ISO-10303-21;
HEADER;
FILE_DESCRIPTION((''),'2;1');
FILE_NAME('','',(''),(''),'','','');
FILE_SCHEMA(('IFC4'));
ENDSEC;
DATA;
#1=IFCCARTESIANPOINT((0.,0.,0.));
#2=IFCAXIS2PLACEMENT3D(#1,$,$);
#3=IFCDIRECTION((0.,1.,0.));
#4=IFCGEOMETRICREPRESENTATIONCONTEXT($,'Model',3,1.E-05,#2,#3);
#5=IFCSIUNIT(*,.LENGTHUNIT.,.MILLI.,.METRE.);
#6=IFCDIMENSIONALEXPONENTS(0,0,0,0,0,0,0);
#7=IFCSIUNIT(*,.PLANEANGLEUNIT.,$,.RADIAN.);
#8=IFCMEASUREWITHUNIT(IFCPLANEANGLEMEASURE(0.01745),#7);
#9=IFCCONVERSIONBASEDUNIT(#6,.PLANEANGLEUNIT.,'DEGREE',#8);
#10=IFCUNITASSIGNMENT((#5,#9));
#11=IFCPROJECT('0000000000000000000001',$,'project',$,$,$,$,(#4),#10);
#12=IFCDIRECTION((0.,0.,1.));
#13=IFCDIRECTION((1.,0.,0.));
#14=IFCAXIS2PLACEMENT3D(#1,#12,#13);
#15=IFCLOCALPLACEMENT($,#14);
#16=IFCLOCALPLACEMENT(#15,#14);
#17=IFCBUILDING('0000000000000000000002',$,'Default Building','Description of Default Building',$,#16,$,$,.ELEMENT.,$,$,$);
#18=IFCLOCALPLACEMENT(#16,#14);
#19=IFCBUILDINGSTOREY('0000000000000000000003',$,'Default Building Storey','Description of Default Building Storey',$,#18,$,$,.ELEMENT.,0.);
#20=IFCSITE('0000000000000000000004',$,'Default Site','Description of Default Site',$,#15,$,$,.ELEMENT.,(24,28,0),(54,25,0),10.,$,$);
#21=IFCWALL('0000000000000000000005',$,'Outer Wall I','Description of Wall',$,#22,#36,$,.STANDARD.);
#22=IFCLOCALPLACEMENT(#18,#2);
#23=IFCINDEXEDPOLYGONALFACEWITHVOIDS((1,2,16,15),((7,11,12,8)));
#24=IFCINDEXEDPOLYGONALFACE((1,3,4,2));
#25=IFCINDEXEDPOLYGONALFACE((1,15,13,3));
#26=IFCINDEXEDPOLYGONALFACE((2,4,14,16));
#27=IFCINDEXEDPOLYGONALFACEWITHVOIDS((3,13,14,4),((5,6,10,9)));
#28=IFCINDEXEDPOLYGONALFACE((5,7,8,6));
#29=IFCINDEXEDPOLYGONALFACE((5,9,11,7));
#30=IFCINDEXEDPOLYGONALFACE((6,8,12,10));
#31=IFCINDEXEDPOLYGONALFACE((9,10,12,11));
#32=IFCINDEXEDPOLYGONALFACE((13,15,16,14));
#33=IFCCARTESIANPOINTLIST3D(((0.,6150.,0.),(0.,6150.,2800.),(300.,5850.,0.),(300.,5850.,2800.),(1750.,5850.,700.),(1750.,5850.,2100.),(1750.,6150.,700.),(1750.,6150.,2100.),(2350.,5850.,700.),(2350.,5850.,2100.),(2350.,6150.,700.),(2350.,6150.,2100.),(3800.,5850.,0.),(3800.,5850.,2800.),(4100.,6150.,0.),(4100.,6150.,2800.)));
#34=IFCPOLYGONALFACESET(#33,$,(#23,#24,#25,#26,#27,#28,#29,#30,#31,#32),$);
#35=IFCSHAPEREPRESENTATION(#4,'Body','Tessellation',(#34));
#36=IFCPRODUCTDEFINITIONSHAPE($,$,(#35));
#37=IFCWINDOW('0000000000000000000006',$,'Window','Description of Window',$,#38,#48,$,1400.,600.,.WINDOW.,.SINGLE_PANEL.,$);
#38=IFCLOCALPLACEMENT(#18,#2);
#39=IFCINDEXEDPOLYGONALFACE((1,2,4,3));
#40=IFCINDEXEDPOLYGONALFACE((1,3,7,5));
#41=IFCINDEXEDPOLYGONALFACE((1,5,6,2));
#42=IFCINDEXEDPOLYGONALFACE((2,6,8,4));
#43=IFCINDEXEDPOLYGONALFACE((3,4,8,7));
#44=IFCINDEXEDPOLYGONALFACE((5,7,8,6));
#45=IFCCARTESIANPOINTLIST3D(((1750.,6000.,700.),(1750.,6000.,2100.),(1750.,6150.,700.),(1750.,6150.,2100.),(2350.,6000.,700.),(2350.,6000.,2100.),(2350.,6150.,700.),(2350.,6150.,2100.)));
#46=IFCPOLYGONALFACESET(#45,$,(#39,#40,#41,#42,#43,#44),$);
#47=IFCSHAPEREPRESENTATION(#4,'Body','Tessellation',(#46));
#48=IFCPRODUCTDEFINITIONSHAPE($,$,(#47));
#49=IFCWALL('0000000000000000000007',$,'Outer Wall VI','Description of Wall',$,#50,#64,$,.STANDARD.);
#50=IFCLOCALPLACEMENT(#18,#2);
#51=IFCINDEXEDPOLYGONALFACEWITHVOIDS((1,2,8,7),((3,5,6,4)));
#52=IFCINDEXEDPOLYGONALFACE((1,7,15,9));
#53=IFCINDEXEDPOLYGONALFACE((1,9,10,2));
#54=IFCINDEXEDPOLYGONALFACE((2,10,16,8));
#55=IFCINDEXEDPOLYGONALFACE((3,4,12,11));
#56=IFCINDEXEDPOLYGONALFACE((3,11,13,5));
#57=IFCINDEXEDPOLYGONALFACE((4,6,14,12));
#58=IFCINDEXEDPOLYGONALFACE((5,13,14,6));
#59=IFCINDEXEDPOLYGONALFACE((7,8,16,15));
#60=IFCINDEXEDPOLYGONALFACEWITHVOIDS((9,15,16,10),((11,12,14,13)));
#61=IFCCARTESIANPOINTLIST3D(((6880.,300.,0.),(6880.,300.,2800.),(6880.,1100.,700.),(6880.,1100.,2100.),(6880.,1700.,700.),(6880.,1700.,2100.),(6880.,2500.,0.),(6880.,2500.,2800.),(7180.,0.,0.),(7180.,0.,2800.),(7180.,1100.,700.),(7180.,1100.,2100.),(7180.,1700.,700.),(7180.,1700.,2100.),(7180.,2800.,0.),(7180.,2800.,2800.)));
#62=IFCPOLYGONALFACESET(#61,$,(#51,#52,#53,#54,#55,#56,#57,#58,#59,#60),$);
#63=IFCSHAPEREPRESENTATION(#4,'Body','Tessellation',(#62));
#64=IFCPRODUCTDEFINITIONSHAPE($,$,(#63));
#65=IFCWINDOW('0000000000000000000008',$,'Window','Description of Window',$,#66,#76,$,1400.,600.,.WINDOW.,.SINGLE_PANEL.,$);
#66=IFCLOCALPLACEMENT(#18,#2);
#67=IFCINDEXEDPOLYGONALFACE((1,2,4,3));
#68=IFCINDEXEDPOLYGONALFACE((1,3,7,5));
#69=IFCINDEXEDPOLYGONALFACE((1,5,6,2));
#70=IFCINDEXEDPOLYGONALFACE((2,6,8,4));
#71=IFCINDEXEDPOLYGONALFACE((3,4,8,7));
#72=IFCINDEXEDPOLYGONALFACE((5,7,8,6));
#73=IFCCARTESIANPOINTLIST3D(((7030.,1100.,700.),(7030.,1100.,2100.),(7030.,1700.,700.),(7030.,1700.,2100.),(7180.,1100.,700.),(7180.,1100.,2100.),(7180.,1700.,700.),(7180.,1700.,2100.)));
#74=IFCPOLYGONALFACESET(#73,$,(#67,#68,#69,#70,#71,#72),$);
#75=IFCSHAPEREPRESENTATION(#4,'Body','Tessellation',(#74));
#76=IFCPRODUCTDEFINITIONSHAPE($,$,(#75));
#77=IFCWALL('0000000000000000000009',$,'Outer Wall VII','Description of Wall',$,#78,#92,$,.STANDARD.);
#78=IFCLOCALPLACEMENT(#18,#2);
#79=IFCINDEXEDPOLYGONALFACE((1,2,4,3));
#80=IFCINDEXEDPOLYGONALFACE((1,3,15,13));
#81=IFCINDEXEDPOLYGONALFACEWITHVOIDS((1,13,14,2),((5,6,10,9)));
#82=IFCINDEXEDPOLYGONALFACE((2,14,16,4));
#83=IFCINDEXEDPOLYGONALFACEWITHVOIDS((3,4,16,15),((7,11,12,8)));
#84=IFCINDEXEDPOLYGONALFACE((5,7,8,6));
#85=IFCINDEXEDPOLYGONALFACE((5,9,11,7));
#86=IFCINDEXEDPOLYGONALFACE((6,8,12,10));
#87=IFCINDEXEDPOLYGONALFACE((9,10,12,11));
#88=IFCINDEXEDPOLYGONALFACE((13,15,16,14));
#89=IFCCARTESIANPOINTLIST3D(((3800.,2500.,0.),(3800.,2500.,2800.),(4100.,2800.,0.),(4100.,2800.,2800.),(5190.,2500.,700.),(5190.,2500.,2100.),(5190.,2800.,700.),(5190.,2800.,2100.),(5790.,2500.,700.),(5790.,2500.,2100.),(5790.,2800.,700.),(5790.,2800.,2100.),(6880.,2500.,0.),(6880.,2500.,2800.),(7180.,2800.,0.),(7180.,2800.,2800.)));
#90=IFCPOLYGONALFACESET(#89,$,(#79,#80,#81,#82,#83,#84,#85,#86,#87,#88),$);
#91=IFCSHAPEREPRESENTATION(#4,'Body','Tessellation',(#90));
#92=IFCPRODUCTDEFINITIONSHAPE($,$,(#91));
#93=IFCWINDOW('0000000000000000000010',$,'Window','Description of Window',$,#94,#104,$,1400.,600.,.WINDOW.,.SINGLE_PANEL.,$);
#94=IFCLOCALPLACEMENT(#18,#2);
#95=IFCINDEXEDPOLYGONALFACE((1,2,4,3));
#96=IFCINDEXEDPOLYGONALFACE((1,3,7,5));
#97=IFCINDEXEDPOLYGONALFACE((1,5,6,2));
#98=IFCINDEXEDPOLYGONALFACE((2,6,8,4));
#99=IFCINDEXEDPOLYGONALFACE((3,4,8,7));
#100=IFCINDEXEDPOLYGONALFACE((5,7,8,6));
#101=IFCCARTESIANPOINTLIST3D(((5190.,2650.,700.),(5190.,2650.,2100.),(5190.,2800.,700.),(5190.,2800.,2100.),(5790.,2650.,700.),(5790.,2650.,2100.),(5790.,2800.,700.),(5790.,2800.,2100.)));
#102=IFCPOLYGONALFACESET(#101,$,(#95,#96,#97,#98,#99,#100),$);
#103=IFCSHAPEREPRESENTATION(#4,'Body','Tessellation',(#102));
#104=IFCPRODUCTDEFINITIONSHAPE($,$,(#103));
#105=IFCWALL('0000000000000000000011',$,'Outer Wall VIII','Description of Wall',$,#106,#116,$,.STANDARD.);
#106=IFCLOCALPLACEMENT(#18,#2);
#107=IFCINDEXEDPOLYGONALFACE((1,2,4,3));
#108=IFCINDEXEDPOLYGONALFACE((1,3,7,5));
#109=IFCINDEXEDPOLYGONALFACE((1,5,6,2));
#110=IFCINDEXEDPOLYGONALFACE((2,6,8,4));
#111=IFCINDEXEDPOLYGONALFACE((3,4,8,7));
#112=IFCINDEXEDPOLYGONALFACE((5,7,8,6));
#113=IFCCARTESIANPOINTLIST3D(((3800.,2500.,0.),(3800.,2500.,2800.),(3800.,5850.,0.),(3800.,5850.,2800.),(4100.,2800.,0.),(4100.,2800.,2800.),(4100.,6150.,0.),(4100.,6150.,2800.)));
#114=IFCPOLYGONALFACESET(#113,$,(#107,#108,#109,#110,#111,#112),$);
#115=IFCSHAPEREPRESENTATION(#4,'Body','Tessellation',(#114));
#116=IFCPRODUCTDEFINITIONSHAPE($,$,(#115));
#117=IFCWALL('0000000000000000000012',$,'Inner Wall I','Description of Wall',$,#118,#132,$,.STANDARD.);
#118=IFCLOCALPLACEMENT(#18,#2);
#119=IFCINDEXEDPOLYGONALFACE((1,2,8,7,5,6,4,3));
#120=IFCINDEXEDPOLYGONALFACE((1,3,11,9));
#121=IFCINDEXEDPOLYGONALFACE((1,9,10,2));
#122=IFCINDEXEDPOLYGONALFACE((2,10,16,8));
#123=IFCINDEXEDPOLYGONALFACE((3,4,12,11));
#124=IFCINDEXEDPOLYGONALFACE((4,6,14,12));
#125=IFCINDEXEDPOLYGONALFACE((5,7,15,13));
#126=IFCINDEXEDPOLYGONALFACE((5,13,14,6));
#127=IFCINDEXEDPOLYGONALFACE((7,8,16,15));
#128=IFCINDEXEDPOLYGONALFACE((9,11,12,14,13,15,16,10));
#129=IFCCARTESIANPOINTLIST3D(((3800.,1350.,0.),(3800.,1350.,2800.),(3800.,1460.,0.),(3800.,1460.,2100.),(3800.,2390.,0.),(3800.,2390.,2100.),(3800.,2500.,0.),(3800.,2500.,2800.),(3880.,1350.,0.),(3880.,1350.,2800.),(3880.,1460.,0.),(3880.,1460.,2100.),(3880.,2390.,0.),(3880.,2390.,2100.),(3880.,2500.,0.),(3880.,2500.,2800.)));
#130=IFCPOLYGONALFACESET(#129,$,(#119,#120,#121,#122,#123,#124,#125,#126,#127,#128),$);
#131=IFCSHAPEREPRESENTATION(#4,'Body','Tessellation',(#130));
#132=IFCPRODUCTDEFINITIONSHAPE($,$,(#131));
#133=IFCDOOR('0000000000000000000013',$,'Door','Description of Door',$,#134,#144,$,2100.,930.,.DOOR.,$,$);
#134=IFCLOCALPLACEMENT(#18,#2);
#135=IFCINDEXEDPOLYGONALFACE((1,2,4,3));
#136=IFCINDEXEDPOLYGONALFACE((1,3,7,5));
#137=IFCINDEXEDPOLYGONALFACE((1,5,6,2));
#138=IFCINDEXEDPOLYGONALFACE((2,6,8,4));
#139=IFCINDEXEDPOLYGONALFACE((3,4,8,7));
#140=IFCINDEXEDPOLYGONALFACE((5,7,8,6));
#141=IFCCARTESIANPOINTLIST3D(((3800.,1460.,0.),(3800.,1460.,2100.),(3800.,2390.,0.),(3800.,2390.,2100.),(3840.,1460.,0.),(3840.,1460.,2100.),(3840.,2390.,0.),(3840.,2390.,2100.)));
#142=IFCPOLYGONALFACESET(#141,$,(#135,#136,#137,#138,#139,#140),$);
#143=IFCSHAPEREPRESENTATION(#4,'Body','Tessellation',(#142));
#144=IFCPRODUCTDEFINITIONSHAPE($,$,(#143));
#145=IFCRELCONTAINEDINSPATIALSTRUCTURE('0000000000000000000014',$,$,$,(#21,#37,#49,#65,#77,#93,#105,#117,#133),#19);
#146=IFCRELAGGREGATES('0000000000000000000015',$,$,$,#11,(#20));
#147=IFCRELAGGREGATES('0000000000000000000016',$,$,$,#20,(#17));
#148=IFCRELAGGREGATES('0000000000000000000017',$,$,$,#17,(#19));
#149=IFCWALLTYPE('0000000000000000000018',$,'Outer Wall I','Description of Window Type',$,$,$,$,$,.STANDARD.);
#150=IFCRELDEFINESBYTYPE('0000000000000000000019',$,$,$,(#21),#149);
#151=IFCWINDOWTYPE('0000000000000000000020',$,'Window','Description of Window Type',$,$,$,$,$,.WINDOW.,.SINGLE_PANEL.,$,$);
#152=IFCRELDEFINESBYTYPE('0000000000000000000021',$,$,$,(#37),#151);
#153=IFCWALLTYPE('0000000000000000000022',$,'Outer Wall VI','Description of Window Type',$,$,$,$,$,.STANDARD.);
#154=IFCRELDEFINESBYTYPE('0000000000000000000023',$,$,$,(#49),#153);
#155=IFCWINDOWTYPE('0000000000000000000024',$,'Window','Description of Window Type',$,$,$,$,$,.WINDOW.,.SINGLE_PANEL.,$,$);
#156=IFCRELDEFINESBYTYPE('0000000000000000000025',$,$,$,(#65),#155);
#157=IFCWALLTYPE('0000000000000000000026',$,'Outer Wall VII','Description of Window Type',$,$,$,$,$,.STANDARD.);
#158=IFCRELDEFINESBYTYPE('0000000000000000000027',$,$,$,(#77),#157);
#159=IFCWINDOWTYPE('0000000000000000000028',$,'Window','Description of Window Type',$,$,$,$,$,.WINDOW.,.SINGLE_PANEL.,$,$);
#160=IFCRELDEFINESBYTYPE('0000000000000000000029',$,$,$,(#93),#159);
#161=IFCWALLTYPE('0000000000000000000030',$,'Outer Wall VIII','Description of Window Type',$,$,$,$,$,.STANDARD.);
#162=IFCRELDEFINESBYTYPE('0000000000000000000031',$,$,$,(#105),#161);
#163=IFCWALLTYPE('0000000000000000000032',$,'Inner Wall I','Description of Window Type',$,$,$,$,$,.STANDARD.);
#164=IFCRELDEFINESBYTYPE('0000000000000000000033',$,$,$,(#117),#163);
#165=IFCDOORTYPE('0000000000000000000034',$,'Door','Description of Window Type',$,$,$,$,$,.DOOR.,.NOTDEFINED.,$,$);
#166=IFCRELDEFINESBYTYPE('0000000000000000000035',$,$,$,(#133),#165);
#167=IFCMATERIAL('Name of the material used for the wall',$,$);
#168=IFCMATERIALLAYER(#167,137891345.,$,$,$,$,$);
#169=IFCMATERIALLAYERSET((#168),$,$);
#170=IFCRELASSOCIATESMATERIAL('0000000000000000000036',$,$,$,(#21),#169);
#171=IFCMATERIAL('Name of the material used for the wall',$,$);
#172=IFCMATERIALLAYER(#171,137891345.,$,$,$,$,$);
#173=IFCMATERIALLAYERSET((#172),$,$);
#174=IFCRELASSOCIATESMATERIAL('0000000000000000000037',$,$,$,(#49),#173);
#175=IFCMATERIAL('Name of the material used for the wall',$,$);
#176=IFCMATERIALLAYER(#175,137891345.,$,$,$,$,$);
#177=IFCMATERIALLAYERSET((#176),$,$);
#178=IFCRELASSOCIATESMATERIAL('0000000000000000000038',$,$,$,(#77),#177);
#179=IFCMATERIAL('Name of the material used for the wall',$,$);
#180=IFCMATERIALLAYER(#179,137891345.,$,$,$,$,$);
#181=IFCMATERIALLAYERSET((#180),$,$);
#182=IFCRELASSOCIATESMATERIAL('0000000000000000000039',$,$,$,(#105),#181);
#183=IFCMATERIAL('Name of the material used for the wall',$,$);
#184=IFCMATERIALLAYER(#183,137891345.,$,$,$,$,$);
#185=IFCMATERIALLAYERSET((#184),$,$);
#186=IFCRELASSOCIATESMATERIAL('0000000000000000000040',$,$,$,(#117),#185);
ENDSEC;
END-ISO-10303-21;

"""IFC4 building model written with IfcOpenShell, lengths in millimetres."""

from ifc_helpers import new_model, entity, si_unit, converted_unit, direction, frame, origin, origin_with_axes, place, context, project, spatial, polyline, outline, extrude, material, layer, layer_set, layer_usage, type_object, element, fill, save


model = new_model("IFC4")

# Units and contexts
model_context = context("Model", 3, precision=1e-05, world=origin(), true_north=direction((0.0, 1.0, 0.0)))
ifc_project = project(units=[si_unit("LENGTHUNIT", "METRE", prefix="MILLI"), converted_unit("PLANEANGLEUNIT", "DEGREE", entity("IfcPlaneAngleMeasure", 0.01745), si_unit("PLANEANGLEUNIT", "RADIAN"), dimensions=[0, 0, 0, 0, 0, 0, 0])], contexts=[model_context])

# Site, building, storey
site_placement = place(None, origin_with_axes())
site = spatial("IfcSite", under=ifc_project, at=site_placement, Name="Default Site", Description="Description of Default Site", CompositionType="ELEMENT", RefLatitude=(24, 28, 0), RefLongitude=(54, 25, 0), RefElevation=10.0)
building_placement = place(site_placement, origin_with_axes())
building = spatial("IfcBuilding", under=site, at=building_placement, Name="Default Building", Description="Description of Default Building", CompositionType="ELEMENT")
storey_placement = place(building_placement, origin_with_axes())
storey = spatial("IfcBuildingStorey", under=building, at=storey_placement, Name="Default Building Storey", Description="Description of Default Building Storey", CompositionType="ELEMENT", Elevation=0.0)

# Walls, openings, windows
ifc_material_1 = material(Name="Name of the material used for the wall")
ifc_layer_1 = layer(ifc_material_1, 137891345.0)
ifc_layer_set_1 = layer_set([ifc_layer_1])
ifc_layer_usage_1 = layer_usage(ifc_layer_set_1, "AXIS2", "POSITIVE", -68945672.5)
wall_type_1 = type_object("IfcWallType", Name="Outer Wall I", Description="Description of Window Type", PredefinedType="STANDARD")
wall_1_placement = place(storey_placement, frame((3950.0, 6000.0, 0.0), z_axis=(0.0, 0.0, 1.0), x_axis=(-1.0, 0.0, 0.0)))
wall_1 = element("IfcWall", 1, at=wall_1_placement, inside=storey, type_object=wall_type_1, material=ifc_layer_usage_1, Name="Outer Wall I", Description="Description of Wall", PredefinedType="STANDARD", context=model_context, shape_type="SweptSolid", body=[
    extrude(outline(polyline([(-150.0, -150.0), (150.0, 150.0), (3650.0, 150.0), (3950.0, -150.0), (-150.0, -150.0)])), origin_with_axes(), (0.0, 0.0, 1.0), 2800.0),
])
opening_1_placement = place(wall_1_placement, frame((1600.0, -150.0, 700.0), z_axis=(0.0, 0.0, 1.0), x_axis=(1.0, 0.0, 0.0)))
opening_1 = element("IfcOpeningElement", 2, at=opening_1_placement, cuts=wall_1, context=model_context, shape_type="SweptSolid", body=[
    extrude(outline(polyline([(0.0, 0.0), (0.0, 300.0), (600.0, 300.0), (600.0, 0.0), (0.0, 0.0)])), origin_with_axes(), (0.0, 0.0, 1.0), 1400.0),
])
window_type_1 = type_object("IfcWindowType", Name="Window", Description="Description of Window Type", PartitioningType="SINGLE_PANEL", PredefinedType="WINDOW")
window_1_placement = place(opening_1_placement, origin_with_axes())
window_1 = element("IfcWindow", 3, at=window_1_placement, inside=storey, type_object=window_type_1, Name="Window", Description="Description of Window", OverallHeight=1400.0, OverallWidth=600.0, PartitioningType="SINGLE_PANEL", PredefinedType="WINDOW", context=model_context, shape_type="SweptSolid", body=[
    extrude(outline(polyline([(0.0, 0.0), (0.0, 150.0), (600.0, 150.0), (600.0, 0.0), (0.0, 0.0)])), origin_with_axes(), (0.0, 0.0, 1.0), 1400.0),
])
fill(opening_1, window_1)
ifc_material_2 = material(Name="Name of the material used for the wall")
ifc_layer_2 = layer(ifc_material_2, 137891345.0)
ifc_layer_set_2 = layer_set([ifc_layer_2])
ifc_layer_usage_2 = layer_usage(ifc_layer_set_2, "AXIS2", "POSITIVE", -68945672.5)
wall_type_2 = type_object("IfcWallType", Name="Outer Wall VI", Description="Description of Window Type", PredefinedType="STANDARD")
wall_2_placement = place(storey_placement, frame((7030.0, 150.0, 0.0), z_axis=(0.0, 0.0, 1.0), x_axis=(0.0, 1.0, 0.0)))
wall_2 = element("IfcWall", 4, at=wall_2_placement, inside=storey, type_object=wall_type_2, material=ifc_layer_usage_2, Name="Outer Wall VI", Description="Description of Wall", PredefinedType="STANDARD", context=model_context, shape_type="SweptSolid", body=[
    extrude(outline(polyline([(-150.0, -150.0), (150.0, 150.0), (2350.0, 150.0), (2650.0, -150.0), (-150.0, -150.0)])), origin_with_axes(), (0.0, 0.0, 1.0), 2800.0),
])
opening_2_placement = place(wall_2_placement, frame((950.0, -150.0, 700.0), z_axis=(0.0, 0.0, 1.0), x_axis=(1.0, 0.0, 0.0)))
opening_2 = element("IfcOpeningElement", 5, at=opening_2_placement, cuts=wall_2, context=model_context, shape_type="SweptSolid", body=[
    extrude(outline(polyline([(0.0, 0.0), (0.0, 300.0), (600.0, 300.0), (600.0, 0.0), (0.0, 0.0)])), origin_with_axes(), (0.0, 0.0, 1.0), 1400.0),
])
window_type_2 = type_object("IfcWindowType", Name="Window", Description="Description of Window Type", PartitioningType="SINGLE_PANEL", PredefinedType="WINDOW")
window_2_placement = place(opening_2_placement, origin_with_axes())
window_2 = element("IfcWindow", 6, at=window_2_placement, inside=storey, type_object=window_type_2, Name="Window", Description="Description of Window", OverallHeight=1400.0, OverallWidth=600.0, PartitioningType="SINGLE_PANEL", PredefinedType="WINDOW", context=model_context, shape_type="SweptSolid", body=[
    extrude(outline(polyline([(0.0, 0.0), (0.0, 150.0), (600.0, 150.0), (600.0, 0.0), (0.0, 0.0)])), origin_with_axes(), (0.0, 0.0, 1.0), 1400.0),
])
fill(opening_2, window_2)
ifc_material_3 = material(Name="Name of the material used for the wall")
ifc_layer_3 = layer(ifc_material_3, 137891345.0)
ifc_layer_set_3 = layer_set([ifc_layer_3])
ifc_layer_usage_3 = layer_usage(ifc_layer_set_3, "AXIS2", "POSITIVE", -68945672.5)
wall_type_3 = type_object("IfcWallType", Name="Outer Wall VII", Description="Description of Window Type", PredefinedType="STANDARD")
wall_3_placement = place(storey_placement, frame((7030.0, 2650.0, 0.0), z_axis=(0.0, 0.0, 1.0), x_axis=(-1.0, 0.0, 0.0)))
wall_3 = element("IfcWall", 7, at=wall_3_placement, inside=storey, type_object=wall_type_3, material=ifc_layer_usage_3, Name="Outer Wall VII", Description="Description of Wall", PredefinedType="STANDARD", context=model_context, shape_type="SweptSolid", body=[
    extrude(outline(polyline([(-150.0, -150.0), (150.0, 150.0), (3230.0, 150.0), (2930.0, -150.0), (-150.0, -150.0)])), origin_with_axes(), (0.0, 0.0, 1.0), 2800.0),
])
opening_3_placement = place(wall_3_placement, frame((1240.0, -150.0, 700.0), z_axis=(0.0, 0.0, 1.0), x_axis=(1.0, 0.0, 0.0)))
opening_3 = element("IfcOpeningElement", 8, at=opening_3_placement, cuts=wall_3, context=model_context, shape_type="SweptSolid", body=[
    extrude(outline(polyline([(0.0, 0.0), (0.0, 300.0), (600.0, 300.0), (600.0, 0.0), (0.0, 0.0)])), origin_with_axes(), (0.0, 0.0, 1.0), 1400.0),
])
window_type_3 = type_object("IfcWindowType", Name="Window", Description="Description of Window Type", PartitioningType="SINGLE_PANEL", PredefinedType="WINDOW")
window_3_placement = place(opening_3_placement, origin_with_axes())
window_3 = element("IfcWindow", 9, at=window_3_placement, inside=storey, type_object=window_type_3, Name="Window", Description="Description of Window", OverallHeight=1400.0, OverallWidth=600.0, PartitioningType="SINGLE_PANEL", PredefinedType="WINDOW", context=model_context, shape_type="SweptSolid", body=[
    extrude(outline(polyline([(0.0, 0.0), (0.0, 150.0), (600.0, 150.0), (600.0, 0.0), (0.0, 0.0)])), origin_with_axes(), (0.0, 0.0, 1.0), 1400.0),
])
fill(opening_3, window_3)

# Wall
ifc_material_4 = material(Name="Name of the material used for the wall")
ifc_layer_4 = layer(ifc_material_4, 137891345.0)
ifc_layer_set_4 = layer_set([ifc_layer_4])
ifc_layer_usage_4 = layer_usage(ifc_layer_set_4, "AXIS2", "POSITIVE", -68945672.5)
wall_type_4 = type_object("IfcWallType", Name="Outer Wall VIII", Description="Description of Window Type", PredefinedType="STANDARD")
wall_4_placement = place(storey_placement, frame((3950.0, 2650.0, 0.0), z_axis=(0.0, 0.0, 1.0), x_axis=(0.0, 1.0, 0.0)))
element("IfcWall", 10, at=wall_4_placement, inside=storey, type_object=wall_type_4, material=ifc_layer_usage_4, Name="Outer Wall VIII", Description="Description of Wall", PredefinedType="STANDARD", context=model_context, shape_type="SweptSolid", body=[
    extrude(outline(polyline([(150.0, -150.0), (-150.0, 150.0), (3200.0, 150.0), (3500.0, -150.0), (150.0, -150.0)])), origin_with_axes(), (0.0, 0.0, 1.0), 2800.0),
])

# Wall, opening, door
ifc_material_5 = material(Name="Name of the material used for the wall")
ifc_layer_5 = layer(ifc_material_5, 137891345.0)
ifc_layer_set_5 = layer_set([ifc_layer_5])
ifc_layer_usage_5 = layer_usage(ifc_layer_set_5, "AXIS2", "POSITIVE", -68945672.5)
wall_type_5 = type_object("IfcWallType", Name="Inner Wall I", Description="Description of Window Type", PredefinedType="STANDARD")
wall_5_placement = place(storey_placement, frame((3840.0, 2500.0, 0.0), z_axis=(0.0, 0.0, 1.0), x_axis=(0.0, -1.0, 0.0)))
wall_5 = element("IfcWall", 11, at=wall_5_placement, inside=storey, type_object=wall_type_5, material=ifc_layer_usage_5, Name="Inner Wall I", Description="Description of Wall", PredefinedType="STANDARD", context=model_context, shape_type="SweptSolid", body=[
    extrude(outline(polyline([(0.0, -40.0), (0.0, 40.0), (1150.0, 40.0), (1150.0, -40.0), (0.0, -40.0)])), origin_with_axes(), (0.0, 0.0, 1.0), 2800.0),
])
opening_4_placement = place(wall_5_placement, frame((110.0, -40.0, 0.0), z_axis=(0.0, 0.0, 1.0), x_axis=(1.0, 0.0, 0.0)))
opening_4 = element("IfcOpeningElement", 12, at=opening_4_placement, cuts=wall_5, context=model_context, shape_type="SweptSolid", body=[
    extrude(outline(polyline([(0.0, 0.0), (0.0, 80.0), (930.0, 80.0), (930.0, 0.0), (0.0, 0.0)])), origin_with_axes(), (0.0, 0.0, 1.0), 2100.0),
])
door_type_1 = type_object("IfcDoorType", Name="Door", Description="Description of Window Type", PredefinedType="DOOR")
door_1_placement = place(opening_4_placement, origin_with_axes())
door_1 = element("IfcDoor", 13, at=door_1_placement, inside=storey, type_object=door_type_1, Name="Door", Description="Description of Door", OverallHeight=2100.0, OverallWidth=930.0, PredefinedType="DOOR", context=model_context, shape_type="SweptSolid", body=[
    extrude(outline(polyline([(0.0, 0.0), (0.0, 40.0), (930.0, 40.0), (930.0, 0.0), (0.0, 0.0)])), origin_with_axes(), (0.0, 0.0, 1.0), 2100.0),
])
fill(opening_4, door_1)

save(model, "model.ifc")
